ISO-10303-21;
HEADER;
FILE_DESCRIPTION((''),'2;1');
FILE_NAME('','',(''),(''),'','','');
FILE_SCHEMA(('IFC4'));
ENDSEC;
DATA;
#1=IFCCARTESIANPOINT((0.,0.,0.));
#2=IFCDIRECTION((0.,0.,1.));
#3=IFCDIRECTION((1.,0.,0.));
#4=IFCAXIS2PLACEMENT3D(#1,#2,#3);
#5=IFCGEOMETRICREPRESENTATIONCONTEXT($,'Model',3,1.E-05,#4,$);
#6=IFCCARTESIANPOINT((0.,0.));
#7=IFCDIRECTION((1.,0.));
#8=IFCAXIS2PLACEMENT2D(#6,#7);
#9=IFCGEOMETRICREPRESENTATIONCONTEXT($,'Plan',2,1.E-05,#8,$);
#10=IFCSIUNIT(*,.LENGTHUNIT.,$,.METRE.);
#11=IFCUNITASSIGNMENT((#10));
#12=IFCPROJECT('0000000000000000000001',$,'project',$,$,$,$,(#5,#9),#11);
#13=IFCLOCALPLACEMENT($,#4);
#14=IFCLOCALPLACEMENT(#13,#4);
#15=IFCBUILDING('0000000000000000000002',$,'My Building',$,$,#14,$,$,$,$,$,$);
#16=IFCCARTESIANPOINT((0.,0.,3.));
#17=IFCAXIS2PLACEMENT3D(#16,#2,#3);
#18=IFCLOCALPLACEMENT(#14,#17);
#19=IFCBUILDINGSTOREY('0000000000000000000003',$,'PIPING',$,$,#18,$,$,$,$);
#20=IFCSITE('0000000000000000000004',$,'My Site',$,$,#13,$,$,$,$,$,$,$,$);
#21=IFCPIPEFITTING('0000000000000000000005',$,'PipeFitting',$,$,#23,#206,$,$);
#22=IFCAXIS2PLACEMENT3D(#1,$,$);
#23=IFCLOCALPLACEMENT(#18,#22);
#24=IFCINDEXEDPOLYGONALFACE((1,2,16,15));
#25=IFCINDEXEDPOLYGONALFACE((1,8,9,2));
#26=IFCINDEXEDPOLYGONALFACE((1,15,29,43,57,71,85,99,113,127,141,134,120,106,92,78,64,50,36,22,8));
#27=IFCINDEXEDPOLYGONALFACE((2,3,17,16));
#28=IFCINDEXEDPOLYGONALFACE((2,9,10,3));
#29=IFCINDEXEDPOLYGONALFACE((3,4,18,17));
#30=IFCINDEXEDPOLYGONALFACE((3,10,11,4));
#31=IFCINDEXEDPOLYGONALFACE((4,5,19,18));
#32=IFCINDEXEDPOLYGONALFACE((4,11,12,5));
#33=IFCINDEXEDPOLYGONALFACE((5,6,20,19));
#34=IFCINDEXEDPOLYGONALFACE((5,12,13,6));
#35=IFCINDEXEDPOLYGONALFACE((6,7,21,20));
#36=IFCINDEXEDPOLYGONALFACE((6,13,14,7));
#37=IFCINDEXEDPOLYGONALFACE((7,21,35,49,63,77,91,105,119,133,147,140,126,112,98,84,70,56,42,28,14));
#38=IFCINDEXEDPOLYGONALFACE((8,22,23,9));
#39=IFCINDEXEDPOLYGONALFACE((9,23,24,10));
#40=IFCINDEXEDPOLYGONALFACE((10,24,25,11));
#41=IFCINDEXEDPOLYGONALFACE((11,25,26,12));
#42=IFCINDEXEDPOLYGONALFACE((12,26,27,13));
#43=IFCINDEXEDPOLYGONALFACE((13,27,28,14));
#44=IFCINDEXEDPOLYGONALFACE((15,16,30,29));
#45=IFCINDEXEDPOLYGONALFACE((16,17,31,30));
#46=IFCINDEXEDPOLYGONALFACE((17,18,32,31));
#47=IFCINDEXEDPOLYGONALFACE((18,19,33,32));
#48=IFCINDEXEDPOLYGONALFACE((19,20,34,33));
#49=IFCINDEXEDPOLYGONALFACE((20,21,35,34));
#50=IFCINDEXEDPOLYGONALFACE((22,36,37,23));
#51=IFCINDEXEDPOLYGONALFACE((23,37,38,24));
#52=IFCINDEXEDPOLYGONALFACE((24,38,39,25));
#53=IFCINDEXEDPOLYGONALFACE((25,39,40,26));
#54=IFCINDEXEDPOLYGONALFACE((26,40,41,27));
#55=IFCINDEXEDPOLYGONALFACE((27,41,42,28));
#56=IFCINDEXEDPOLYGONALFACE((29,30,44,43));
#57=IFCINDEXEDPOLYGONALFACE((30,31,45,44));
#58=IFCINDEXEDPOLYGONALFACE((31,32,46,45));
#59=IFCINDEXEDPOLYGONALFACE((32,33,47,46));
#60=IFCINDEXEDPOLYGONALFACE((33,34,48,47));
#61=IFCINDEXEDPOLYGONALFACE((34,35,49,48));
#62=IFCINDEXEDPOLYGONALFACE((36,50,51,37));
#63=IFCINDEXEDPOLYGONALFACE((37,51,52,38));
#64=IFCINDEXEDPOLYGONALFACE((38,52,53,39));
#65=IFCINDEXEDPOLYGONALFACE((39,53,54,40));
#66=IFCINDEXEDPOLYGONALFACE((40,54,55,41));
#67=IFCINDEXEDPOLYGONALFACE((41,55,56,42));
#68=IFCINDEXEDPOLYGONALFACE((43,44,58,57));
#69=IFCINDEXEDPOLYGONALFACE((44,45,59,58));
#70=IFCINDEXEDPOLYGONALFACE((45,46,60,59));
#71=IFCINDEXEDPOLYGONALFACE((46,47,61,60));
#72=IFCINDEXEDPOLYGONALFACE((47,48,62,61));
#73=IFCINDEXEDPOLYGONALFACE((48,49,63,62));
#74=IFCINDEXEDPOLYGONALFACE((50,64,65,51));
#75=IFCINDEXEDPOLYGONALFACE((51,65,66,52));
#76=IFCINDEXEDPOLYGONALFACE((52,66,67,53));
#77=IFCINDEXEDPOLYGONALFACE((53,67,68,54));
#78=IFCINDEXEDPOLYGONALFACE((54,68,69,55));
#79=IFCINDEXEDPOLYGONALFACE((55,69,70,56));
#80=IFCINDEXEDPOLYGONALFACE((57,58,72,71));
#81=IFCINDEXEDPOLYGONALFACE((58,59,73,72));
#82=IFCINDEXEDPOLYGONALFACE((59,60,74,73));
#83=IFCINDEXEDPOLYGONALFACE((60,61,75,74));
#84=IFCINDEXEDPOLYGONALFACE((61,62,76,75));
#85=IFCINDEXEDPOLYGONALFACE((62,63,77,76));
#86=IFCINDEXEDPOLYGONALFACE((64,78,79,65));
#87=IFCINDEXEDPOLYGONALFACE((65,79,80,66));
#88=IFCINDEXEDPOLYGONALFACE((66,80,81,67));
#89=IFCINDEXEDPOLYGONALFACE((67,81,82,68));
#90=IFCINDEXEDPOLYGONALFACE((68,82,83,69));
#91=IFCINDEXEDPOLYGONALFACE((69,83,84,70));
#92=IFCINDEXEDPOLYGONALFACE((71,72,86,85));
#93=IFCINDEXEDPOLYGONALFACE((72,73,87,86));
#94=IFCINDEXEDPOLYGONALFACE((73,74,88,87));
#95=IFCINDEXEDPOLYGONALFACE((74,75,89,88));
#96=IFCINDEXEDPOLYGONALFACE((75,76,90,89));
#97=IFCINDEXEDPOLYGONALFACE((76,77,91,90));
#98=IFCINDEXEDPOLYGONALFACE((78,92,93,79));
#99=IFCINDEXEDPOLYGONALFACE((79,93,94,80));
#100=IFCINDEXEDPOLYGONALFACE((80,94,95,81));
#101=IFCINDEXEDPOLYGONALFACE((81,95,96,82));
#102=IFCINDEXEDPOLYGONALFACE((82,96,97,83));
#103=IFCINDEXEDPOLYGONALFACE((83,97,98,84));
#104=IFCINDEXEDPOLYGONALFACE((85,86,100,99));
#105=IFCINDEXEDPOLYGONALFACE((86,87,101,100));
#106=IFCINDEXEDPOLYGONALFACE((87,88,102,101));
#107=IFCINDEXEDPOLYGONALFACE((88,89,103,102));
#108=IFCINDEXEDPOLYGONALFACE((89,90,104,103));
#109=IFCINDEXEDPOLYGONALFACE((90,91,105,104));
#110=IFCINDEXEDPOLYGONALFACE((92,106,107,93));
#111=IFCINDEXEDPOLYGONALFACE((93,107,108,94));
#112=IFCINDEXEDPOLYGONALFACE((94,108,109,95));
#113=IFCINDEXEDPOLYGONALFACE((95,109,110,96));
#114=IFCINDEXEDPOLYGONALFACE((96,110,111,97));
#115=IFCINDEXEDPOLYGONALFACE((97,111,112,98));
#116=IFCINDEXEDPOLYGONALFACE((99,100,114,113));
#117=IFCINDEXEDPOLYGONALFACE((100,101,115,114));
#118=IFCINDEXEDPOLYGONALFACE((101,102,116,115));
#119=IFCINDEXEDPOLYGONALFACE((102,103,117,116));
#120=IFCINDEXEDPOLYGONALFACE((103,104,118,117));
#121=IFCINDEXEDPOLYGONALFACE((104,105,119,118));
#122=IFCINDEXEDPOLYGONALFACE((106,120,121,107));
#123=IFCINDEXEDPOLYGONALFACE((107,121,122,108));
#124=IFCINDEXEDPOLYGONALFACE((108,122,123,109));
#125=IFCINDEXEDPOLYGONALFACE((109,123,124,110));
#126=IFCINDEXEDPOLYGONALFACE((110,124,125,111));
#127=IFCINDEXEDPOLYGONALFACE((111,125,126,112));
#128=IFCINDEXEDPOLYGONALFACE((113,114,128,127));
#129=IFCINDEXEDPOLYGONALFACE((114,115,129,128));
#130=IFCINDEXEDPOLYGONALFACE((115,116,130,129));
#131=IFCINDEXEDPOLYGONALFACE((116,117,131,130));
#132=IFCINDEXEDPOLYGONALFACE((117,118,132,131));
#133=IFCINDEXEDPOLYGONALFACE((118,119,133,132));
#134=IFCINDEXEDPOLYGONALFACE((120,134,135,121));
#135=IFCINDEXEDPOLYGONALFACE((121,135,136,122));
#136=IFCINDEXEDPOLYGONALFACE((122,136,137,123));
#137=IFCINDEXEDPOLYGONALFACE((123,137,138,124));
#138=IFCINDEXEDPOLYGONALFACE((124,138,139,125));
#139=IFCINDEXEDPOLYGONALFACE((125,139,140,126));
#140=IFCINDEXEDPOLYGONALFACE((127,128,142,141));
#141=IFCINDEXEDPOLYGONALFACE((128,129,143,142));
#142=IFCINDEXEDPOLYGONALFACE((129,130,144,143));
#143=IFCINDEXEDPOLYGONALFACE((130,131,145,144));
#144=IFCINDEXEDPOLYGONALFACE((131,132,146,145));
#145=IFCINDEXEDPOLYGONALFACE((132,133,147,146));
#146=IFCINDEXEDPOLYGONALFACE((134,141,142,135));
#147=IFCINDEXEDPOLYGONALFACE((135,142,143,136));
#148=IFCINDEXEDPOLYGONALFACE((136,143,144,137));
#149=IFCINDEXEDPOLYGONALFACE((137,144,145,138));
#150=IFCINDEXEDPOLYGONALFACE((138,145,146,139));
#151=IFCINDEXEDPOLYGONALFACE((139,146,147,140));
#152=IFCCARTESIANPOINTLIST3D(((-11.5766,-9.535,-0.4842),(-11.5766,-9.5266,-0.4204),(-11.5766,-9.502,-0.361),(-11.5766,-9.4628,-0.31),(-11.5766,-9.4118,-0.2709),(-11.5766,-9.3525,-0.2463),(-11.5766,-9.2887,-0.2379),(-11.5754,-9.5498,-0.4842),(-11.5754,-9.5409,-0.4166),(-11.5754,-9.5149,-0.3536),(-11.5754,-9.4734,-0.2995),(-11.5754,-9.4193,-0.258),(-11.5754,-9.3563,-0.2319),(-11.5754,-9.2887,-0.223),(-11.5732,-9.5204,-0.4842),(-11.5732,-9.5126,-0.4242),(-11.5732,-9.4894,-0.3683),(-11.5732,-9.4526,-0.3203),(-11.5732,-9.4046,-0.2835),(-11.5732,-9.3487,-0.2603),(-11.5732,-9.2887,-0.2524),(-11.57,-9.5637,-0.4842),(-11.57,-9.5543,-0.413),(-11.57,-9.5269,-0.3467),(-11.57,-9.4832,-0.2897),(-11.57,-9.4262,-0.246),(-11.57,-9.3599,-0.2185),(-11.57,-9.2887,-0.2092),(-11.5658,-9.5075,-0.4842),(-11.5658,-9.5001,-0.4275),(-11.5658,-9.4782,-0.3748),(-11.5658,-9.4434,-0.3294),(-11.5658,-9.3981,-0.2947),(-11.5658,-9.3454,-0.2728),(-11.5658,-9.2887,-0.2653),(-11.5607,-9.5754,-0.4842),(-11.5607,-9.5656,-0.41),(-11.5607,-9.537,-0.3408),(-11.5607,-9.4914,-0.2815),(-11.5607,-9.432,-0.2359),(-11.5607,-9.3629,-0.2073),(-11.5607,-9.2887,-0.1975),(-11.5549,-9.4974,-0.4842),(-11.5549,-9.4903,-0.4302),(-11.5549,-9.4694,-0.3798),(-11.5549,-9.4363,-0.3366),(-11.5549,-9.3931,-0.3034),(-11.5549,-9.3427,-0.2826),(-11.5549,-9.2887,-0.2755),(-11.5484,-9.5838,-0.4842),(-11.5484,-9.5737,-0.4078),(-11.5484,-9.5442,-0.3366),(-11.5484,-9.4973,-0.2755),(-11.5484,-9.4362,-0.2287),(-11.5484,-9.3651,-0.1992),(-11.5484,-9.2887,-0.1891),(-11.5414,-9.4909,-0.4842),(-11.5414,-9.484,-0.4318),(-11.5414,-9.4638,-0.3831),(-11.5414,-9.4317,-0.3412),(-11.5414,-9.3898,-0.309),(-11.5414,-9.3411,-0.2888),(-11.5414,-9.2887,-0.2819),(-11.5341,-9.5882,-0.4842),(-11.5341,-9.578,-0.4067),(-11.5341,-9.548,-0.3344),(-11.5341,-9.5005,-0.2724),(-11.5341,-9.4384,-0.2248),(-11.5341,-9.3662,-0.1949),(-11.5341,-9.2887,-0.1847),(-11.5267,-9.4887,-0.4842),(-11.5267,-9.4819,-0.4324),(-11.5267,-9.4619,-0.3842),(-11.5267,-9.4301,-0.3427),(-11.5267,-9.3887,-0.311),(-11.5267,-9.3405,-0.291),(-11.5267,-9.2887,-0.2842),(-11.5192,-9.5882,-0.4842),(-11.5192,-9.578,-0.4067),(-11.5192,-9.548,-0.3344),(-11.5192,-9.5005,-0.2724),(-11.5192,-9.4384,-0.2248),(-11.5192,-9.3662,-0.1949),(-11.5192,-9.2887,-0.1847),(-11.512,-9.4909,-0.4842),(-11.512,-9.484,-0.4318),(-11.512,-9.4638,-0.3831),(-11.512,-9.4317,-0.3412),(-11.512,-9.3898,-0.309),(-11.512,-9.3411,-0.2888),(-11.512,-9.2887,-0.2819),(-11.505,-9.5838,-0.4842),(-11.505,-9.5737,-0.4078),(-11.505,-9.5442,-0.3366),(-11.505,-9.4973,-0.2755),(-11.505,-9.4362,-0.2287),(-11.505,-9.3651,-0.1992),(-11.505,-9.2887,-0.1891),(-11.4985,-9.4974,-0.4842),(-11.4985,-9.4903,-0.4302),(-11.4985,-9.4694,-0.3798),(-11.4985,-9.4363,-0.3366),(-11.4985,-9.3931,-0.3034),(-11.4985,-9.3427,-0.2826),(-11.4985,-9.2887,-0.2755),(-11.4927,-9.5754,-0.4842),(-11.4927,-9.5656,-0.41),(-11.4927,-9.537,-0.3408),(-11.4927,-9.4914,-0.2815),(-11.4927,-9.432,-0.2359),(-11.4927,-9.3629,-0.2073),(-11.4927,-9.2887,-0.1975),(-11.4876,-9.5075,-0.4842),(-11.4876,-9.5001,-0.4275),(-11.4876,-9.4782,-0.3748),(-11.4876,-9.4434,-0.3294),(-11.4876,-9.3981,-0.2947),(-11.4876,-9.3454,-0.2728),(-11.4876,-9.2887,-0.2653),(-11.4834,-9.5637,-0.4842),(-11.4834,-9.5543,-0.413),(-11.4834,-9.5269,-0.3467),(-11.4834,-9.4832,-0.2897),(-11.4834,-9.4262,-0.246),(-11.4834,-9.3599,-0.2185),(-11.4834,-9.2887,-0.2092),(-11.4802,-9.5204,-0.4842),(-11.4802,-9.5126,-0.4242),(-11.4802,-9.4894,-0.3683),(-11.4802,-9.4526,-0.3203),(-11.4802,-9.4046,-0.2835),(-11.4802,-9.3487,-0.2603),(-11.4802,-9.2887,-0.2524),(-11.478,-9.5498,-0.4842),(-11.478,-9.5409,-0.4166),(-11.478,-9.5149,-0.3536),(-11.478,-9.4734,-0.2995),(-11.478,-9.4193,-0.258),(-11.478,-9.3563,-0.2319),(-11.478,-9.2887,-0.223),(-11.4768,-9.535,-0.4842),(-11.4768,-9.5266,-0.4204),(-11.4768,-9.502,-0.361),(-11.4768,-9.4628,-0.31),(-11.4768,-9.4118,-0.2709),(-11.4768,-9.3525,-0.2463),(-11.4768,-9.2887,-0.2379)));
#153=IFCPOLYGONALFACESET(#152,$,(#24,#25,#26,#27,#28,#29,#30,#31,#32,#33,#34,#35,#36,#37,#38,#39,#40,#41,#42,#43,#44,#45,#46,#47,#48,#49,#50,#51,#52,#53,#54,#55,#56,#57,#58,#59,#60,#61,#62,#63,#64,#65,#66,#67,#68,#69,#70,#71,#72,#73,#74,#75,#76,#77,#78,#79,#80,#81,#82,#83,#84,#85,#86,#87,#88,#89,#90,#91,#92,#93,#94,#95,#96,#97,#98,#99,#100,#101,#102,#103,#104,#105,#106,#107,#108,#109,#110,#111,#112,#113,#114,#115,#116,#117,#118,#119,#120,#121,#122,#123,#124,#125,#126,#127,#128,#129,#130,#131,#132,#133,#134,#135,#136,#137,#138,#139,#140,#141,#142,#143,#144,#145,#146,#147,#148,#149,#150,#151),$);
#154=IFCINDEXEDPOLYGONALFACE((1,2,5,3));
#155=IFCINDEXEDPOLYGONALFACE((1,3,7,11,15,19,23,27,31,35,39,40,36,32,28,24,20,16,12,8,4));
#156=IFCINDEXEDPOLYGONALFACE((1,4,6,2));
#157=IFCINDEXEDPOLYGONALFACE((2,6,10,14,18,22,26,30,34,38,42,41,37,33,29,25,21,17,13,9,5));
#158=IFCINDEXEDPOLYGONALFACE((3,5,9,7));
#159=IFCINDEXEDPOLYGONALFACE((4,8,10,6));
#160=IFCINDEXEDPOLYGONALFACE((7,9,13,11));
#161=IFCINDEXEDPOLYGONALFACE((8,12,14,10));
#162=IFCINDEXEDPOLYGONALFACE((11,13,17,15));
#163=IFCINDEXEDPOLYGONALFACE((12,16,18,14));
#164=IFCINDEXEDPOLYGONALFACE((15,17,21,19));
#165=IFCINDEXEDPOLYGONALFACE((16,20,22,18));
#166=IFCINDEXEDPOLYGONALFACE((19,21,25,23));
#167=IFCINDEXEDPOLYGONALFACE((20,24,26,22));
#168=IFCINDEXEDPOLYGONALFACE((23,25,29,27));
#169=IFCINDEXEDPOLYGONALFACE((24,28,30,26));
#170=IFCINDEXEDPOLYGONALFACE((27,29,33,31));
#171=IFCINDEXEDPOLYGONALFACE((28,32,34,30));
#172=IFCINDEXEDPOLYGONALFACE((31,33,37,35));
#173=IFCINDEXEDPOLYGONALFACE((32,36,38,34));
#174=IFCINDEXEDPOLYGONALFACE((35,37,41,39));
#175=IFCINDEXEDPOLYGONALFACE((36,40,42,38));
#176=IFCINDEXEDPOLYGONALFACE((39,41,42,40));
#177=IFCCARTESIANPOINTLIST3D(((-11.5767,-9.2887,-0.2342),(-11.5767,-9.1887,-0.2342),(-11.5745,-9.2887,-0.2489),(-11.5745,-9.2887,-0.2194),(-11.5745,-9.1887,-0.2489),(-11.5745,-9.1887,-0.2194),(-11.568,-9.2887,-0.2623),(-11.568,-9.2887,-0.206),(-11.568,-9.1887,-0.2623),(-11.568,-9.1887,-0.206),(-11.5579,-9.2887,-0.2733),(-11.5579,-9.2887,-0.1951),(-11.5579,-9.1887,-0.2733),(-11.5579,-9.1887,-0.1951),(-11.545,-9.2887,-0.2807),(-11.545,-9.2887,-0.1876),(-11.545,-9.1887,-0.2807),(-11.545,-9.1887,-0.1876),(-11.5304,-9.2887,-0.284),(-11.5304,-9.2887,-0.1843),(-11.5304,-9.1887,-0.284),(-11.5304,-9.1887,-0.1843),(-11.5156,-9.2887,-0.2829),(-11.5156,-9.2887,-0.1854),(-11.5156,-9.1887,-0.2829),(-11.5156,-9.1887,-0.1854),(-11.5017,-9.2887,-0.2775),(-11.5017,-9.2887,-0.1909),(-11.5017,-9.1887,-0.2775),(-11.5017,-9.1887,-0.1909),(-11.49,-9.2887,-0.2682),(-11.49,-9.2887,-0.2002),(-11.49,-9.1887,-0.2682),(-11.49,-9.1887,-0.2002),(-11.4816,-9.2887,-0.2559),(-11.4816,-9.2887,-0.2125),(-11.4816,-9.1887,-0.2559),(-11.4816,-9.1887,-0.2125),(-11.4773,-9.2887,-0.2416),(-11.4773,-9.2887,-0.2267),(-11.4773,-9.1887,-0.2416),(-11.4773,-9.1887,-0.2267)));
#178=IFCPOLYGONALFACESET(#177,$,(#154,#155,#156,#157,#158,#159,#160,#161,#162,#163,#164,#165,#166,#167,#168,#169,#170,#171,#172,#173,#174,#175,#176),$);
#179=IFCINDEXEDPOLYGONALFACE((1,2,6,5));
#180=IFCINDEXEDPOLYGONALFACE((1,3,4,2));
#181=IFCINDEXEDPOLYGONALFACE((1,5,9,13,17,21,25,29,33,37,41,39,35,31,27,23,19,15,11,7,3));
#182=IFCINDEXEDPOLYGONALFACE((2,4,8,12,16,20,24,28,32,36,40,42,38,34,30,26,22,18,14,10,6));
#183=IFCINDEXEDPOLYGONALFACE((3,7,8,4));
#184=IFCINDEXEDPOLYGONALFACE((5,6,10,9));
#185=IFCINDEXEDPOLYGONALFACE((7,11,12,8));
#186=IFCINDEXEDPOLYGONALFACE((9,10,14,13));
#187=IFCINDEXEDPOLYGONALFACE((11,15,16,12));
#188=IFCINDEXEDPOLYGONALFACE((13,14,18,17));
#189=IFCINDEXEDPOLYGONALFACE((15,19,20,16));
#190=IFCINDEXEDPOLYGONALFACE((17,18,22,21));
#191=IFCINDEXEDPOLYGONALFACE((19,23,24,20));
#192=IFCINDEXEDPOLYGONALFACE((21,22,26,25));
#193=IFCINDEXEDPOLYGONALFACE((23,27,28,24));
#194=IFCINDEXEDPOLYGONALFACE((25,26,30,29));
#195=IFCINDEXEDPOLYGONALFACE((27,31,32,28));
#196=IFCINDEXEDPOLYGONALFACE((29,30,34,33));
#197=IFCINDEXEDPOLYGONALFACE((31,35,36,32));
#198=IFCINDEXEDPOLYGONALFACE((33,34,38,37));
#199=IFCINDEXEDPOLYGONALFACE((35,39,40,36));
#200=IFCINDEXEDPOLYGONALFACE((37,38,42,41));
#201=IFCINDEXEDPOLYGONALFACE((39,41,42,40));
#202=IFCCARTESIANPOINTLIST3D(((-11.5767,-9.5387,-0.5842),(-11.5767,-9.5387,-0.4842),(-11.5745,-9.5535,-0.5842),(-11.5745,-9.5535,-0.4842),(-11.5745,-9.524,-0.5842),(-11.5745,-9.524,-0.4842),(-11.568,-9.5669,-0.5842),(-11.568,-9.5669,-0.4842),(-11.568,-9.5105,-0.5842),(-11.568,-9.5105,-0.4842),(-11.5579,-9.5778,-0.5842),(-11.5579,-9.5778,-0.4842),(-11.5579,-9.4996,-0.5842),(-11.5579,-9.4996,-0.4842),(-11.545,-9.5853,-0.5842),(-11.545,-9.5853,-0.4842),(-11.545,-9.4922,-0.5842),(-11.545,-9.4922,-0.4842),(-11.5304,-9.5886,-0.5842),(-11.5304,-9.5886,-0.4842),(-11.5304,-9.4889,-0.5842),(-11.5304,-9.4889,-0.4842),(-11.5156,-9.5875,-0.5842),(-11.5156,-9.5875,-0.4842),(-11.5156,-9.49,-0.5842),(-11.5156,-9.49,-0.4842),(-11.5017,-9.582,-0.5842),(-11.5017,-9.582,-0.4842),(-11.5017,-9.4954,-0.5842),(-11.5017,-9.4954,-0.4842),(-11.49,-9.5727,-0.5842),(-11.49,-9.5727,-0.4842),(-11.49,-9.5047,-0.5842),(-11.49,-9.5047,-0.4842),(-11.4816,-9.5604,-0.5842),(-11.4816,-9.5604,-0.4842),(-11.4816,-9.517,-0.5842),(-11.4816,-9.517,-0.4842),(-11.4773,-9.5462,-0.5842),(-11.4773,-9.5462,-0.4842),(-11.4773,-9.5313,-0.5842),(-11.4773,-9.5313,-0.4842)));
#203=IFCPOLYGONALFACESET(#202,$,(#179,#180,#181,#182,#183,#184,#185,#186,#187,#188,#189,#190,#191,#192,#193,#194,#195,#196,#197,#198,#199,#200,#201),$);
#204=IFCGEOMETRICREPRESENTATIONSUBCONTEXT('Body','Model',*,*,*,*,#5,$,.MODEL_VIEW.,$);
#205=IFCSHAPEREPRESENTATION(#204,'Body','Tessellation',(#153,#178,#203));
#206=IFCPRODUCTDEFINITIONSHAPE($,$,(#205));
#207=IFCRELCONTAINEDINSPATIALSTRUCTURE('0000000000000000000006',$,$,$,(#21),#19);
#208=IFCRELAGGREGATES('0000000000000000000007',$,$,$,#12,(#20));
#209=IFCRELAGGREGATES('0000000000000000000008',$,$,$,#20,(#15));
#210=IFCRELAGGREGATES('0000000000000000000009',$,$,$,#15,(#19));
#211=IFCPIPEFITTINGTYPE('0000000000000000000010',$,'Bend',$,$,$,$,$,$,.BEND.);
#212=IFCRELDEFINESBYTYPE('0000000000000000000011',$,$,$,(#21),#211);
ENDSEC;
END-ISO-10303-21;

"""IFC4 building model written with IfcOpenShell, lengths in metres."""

from ifc_helpers import new_model, entity, si_unit, frame, origin_with_axes, origin_2d_with_axis, place, context, subcontext, project, spatial, circle, extrude, source, transform, mapped, type_object, type_shapes, element, save


model = new_model("IFC4")

# Units and contexts
model_context = context("Model", 3, precision=1e-05, world=origin_with_axes())
plan_context = context("Plan", 2, precision=1e-05, world=origin_2d_with_axis())
body_context = subcontext(model_context, "Body", "Model", "MODEL_VIEW")
ifc_project = project(units=[si_unit("LENGTHUNIT", "METRE")], contexts=[model_context, plan_context])

# Site, building, storey
site_placement = place(None, origin_with_axes())
site = spatial("IfcSite", under=ifc_project, at=site_placement, Name="My Site")
building_placement = place(site_placement, origin_with_axes())
building = spatial("IfcBuilding", under=site, at=building_placement, Name="My Building")
storey_placement = place(building_placement, frame((0.0, 0.0, 3.0), z_axis=(0.0, 0.0, 1.0), x_axis=(1.0, 0.0, 0.0)))
storey = spatial("IfcBuildingStorey", under=building, at=storey_placement, Name="PIPING")

# Pipe fitting
pipe_fitting_type = type_object("IfcPipeFittingType", Name="Bend", PredefinedType="BEND")
shared_shape = source(origin_with_axes(), body_context, "Body", "SolidModel", [
    entity("IfcSweptDiskSolid", entity("IfcIndexedPolyCurve", entity("IfcCartesianPointList3D", [[0.0, 0.0, -0.1], [0.0, -0.0732, -0.2768], [0.0, -0.25, -0.35]]), [entity("IfcArcIndex", [1, 2, 3])]), 0.05),
    extrude(circle(Radius=0.05), origin_with_axes(), (0.0, 0.0, -1.0), 0.1),
    extrude(circle(Radius=0.05), frame((0.0, -0.25, -0.35), z_axis=(0.0, -1.0, 0.0), x_axis=(1.0, 0.0, 0.0)), (0.0, 0.0, 1.0), 0.1),
])
type_shapes(pipe_fitting_type, [shared_shape])
for number, where, z_axis, x_axis, name in (
    (1, (-11.5267, -9.1887, -0.2342), (0.0, 1.0, 0.0), (-1.0, 0.0, 0.0), "PipeFitting"),
):
    element("IfcPipeFitting", number, at=place(storey_placement, frame(where, z_axis=z_axis, x_axis=x_axis)), inside=storey, type_object=pipe_fitting_type, Name=name, context=body_context, shape_type="MappedRepresentation", body=[
        mapped(shared_shape, transform((0.0, 0.0, 0.0), x_axis=(1.0, 0.0, 0.0), y_axis=(0.0, 1.0, 0.0), z_axis=(0.0, 0.0, 1.0), scale=1.0)),
    ])

save(model, "model.ifc")
